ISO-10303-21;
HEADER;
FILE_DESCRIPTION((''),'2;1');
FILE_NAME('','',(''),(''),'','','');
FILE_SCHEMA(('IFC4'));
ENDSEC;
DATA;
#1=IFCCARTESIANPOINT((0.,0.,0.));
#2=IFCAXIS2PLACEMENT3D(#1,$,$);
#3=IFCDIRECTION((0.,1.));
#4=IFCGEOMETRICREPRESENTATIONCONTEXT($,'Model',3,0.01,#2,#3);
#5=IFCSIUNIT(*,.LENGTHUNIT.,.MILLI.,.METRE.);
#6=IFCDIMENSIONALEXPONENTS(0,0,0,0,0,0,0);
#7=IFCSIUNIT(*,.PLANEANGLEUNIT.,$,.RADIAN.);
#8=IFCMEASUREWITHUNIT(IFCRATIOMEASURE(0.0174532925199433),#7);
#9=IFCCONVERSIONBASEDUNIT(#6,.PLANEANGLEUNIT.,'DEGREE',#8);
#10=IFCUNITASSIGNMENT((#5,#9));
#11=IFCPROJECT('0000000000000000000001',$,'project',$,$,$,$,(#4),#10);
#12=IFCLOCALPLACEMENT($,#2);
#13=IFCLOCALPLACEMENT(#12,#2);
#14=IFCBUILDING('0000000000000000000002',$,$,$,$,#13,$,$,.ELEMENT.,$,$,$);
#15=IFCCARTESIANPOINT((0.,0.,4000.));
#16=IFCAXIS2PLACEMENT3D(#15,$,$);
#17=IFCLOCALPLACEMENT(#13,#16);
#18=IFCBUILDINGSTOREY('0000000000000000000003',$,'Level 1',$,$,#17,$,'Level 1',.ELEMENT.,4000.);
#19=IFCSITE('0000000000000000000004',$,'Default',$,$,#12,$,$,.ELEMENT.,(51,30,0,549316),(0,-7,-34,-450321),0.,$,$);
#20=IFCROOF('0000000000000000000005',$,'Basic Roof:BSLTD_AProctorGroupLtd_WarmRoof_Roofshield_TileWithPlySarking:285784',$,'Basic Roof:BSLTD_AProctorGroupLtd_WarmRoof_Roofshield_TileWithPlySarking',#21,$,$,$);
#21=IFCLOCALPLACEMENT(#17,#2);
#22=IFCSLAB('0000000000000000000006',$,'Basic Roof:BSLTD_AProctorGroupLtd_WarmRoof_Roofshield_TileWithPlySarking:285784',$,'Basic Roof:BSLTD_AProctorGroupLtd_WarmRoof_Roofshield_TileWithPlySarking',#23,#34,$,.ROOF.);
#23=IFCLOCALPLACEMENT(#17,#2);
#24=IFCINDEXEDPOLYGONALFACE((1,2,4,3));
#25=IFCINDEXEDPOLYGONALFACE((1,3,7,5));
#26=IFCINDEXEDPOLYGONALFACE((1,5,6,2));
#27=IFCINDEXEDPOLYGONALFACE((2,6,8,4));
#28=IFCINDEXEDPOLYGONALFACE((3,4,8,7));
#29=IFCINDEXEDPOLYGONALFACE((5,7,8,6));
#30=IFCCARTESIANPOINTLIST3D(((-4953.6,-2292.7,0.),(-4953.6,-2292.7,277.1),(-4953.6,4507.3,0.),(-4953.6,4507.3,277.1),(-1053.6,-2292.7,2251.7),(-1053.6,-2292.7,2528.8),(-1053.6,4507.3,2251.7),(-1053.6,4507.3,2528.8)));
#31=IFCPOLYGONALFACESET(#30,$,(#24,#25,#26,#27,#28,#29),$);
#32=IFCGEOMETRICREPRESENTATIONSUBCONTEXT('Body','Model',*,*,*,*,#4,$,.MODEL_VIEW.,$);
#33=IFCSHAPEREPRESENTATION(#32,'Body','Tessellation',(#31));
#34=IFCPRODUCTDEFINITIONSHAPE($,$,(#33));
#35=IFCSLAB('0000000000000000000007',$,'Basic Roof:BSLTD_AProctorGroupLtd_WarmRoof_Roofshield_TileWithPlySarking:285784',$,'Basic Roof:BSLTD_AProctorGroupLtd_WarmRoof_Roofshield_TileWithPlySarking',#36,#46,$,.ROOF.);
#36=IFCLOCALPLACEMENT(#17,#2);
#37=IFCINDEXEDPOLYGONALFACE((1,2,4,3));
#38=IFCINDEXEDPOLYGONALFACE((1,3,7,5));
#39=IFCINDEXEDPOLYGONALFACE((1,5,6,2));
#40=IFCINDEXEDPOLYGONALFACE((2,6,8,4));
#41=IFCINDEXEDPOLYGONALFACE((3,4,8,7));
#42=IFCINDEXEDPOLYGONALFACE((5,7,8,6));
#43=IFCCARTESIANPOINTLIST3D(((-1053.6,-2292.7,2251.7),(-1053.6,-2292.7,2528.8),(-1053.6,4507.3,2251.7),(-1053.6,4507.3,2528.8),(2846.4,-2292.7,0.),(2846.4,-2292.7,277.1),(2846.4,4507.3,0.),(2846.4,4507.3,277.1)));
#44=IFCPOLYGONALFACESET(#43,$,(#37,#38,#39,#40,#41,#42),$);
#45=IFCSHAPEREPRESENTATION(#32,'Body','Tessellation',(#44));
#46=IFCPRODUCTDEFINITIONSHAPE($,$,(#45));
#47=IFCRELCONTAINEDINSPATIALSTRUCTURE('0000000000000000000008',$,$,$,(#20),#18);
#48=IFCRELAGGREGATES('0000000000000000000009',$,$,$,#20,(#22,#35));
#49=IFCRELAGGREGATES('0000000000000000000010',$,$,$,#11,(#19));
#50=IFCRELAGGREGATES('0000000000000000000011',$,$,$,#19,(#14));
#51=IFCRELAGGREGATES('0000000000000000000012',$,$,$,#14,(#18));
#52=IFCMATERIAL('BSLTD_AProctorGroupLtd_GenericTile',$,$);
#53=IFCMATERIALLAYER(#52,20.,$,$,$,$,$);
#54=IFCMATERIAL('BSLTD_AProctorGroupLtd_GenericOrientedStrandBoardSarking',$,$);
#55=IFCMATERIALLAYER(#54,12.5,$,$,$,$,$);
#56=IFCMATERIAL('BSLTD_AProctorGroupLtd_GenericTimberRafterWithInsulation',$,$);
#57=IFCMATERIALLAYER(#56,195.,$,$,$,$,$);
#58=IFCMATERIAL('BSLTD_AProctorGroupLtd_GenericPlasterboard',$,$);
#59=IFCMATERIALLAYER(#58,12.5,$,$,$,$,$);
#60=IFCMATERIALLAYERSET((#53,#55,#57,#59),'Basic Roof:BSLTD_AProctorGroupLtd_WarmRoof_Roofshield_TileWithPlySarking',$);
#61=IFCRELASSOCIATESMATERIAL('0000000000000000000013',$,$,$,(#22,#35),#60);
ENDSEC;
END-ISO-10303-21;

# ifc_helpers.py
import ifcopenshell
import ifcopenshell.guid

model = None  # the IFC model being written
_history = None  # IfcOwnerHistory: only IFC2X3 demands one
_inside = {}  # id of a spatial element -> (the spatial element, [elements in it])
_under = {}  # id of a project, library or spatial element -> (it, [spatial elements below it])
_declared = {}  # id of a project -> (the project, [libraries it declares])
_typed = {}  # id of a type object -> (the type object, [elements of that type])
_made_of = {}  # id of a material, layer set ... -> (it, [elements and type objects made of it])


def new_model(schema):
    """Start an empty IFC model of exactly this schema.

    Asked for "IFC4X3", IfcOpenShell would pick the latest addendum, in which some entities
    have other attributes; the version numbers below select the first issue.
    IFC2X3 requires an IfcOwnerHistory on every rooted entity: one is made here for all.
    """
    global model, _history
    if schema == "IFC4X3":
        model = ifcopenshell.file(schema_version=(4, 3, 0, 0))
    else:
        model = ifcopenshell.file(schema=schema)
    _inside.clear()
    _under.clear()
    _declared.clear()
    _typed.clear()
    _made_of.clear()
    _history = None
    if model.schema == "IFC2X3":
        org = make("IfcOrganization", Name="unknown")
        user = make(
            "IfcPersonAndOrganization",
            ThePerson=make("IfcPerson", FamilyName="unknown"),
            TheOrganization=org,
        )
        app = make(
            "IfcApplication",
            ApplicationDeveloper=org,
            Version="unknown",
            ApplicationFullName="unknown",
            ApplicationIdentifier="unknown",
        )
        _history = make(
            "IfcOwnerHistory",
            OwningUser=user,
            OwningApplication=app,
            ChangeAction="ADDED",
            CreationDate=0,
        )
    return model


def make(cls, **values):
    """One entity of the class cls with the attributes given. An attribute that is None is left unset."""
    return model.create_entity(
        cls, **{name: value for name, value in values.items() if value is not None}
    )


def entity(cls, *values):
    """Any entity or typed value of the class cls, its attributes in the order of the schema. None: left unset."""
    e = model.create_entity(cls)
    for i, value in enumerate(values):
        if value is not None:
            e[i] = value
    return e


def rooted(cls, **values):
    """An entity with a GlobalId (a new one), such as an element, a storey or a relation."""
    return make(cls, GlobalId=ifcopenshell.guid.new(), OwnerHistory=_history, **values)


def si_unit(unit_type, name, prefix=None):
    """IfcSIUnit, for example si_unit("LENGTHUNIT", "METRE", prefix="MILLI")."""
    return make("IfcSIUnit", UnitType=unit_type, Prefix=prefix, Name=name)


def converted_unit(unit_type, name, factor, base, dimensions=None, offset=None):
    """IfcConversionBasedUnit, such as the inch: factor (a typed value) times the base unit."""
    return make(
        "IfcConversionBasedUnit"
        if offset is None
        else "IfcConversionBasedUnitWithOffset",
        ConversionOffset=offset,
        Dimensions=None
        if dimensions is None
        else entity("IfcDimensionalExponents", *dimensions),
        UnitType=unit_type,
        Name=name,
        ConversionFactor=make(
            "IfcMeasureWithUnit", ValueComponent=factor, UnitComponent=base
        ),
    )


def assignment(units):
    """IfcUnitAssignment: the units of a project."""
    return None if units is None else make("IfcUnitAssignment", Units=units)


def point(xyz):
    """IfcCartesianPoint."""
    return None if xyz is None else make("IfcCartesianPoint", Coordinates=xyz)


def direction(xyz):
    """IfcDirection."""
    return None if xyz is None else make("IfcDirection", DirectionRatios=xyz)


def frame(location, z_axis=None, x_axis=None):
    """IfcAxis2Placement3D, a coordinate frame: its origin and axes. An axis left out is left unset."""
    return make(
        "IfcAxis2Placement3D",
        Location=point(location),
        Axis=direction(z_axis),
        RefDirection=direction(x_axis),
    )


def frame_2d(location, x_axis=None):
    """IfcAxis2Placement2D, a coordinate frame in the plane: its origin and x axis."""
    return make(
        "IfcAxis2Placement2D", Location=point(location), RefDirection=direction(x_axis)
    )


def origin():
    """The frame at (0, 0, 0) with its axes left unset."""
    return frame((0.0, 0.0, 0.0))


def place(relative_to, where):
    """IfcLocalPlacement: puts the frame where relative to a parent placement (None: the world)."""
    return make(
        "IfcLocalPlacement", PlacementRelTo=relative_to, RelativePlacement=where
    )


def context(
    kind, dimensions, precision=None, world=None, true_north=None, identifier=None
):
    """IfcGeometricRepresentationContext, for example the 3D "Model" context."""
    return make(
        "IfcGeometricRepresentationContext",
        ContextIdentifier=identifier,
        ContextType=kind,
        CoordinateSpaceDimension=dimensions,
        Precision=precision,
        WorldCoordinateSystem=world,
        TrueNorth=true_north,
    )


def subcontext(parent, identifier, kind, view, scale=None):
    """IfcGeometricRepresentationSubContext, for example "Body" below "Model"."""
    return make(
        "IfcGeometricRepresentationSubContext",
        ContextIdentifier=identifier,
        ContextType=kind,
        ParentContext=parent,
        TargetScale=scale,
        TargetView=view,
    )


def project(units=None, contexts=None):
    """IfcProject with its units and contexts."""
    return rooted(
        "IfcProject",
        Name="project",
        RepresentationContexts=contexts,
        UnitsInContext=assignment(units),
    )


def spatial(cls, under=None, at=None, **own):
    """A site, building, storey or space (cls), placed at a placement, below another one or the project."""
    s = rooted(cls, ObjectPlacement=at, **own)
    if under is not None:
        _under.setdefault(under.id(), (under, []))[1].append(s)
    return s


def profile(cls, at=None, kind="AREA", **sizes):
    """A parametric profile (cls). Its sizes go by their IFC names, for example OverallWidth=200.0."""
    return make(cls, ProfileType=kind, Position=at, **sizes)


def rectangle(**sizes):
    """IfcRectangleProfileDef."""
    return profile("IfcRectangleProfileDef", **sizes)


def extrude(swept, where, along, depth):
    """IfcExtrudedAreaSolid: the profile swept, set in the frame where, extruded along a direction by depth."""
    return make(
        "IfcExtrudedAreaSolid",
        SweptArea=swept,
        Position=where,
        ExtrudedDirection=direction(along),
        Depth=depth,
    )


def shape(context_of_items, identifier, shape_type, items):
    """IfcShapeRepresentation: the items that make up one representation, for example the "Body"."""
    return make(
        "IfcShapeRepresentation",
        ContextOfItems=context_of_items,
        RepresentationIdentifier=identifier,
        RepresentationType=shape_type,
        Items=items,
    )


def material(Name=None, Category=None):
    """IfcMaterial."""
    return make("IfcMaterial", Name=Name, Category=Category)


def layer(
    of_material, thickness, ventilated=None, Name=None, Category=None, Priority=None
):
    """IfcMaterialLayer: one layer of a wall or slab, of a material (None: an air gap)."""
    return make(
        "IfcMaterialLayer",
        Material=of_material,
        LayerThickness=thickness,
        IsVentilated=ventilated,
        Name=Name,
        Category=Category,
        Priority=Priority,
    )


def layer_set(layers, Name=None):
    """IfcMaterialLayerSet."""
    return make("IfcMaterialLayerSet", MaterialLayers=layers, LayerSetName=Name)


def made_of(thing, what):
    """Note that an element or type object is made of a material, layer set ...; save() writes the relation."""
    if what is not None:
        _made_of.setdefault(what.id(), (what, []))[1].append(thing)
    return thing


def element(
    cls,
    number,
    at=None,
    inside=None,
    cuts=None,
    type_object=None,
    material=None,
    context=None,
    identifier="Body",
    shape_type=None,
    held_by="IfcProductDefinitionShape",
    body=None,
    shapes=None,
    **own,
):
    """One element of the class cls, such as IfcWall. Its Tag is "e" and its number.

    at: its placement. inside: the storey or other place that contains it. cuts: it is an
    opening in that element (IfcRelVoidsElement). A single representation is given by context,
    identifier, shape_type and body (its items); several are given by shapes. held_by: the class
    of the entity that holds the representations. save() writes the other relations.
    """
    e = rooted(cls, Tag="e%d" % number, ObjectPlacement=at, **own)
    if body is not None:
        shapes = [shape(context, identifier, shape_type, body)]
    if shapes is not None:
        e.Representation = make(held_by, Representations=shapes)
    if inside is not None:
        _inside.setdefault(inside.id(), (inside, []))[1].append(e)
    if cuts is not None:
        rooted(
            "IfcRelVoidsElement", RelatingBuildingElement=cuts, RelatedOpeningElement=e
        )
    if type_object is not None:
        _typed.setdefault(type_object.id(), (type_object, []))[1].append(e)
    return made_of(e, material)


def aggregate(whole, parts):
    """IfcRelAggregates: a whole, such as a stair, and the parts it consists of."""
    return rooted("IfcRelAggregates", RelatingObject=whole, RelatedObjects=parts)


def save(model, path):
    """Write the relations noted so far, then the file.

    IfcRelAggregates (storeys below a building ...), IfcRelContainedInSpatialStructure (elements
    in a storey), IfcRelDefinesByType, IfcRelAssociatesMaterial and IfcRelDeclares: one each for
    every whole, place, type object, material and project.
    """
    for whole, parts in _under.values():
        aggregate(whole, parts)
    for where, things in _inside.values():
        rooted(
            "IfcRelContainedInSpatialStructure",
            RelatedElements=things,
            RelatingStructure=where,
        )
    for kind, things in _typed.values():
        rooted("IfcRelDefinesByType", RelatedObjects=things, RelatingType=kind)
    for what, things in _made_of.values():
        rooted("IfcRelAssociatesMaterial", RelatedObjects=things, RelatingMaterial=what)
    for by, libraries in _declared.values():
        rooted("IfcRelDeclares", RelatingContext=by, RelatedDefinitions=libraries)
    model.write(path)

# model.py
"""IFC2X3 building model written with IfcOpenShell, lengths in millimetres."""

from ifc_helpers import new_model, entity, si_unit, converted_unit, direction, frame, frame_2d, origin, place, context, subcontext, project, spatial, rectangle, extrude, material, layer, layer_set, element, aggregate, save


model = new_model("IFC2X3")

# Units and contexts
model_context = context("Model", 3, precision=0.01, world=origin(), true_north=direction((0.0, 1.0)))
body_context = subcontext(model_context, "Body", "Model", "MODEL_VIEW")
ifc_project = project(units=[si_unit("LENGTHUNIT", "METRE", prefix="MILLI"), converted_unit("PLANEANGLEUNIT", "DEGREE", entity("IfcRatioMeasure", 0.0174532925199433), si_unit("PLANEANGLEUNIT", "RADIAN"), dimensions=[0, 0, 0, 0, 0, 0, 0])], contexts=[model_context])

# Site, building, storey
site_placement = place(None, origin())
site = spatial("IfcSite", under=ifc_project, at=site_placement, Name="Default", CompositionType="ELEMENT", RefLatitude=(51, 30, 0, 549316), RefLongitude=(0, -7, -34, -450321), RefElevation=0.0)
building_placement = place(site_placement, origin())
building = spatial("IfcBuilding", under=site, at=building_placement, CompositionType="ELEMENT")
storey_placement = place(building_placement, frame((0.0, 0.0, 4000.0)))
storey = spatial("IfcBuildingStorey", under=building, at=storey_placement, Name="Level 1", LongName="Level 1", CompositionType="ELEMENT", Elevation=4000.0)

# Roof, slabs
roof_placement = place(storey_placement, frame((-4953.6, -2292.7, 0.0)))
roof = element("IfcRoof", 1, at=roof_placement, inside=storey, Name="Basic Roof:BSLTD_AProctorGroupLtd_WarmRoof_Roofshield_TileWithPlySarking:285784", ObjectType="Basic Roof:BSLTD_AProctorGroupLtd_WarmRoof_Roofshield_TileWithPlySarking")
ifc_material_1 = material(Name="BSLTD_AProctorGroupLtd_GenericTile")
ifc_layer_1 = layer(ifc_material_1, 20.0)
ifc_material_2 = material(Name="BSLTD_AProctorGroupLtd_GenericOrientedStrandBoardSarking")
ifc_layer_2 = layer(ifc_material_2, 12.5)
ifc_material_3 = material(Name="BSLTD_AProctorGroupLtd_GenericTimberRafterWithInsulation")
ifc_layer_3 = layer(ifc_material_3, 195.0)
ifc_material_4 = material(Name="BSLTD_AProctorGroupLtd_GenericPlasterboard")
ifc_layer_4 = layer(ifc_material_4, 12.5)
ifc_layer_set = layer_set([ifc_layer_1, ifc_layer_2, ifc_layer_3, ifc_layer_4], Name="Basic Roof:BSLTD_AProctorGroupLtd_WarmRoof_Roofshield_TileWithPlySarking")
slab_1_placement = place(roof_placement, origin())
slab_1 = element("IfcSlab", 2, at=slab_1_placement, material=ifc_layer_set, Name="Basic Roof:BSLTD_AProctorGroupLtd_WarmRoof_Roofshield_TileWithPlySarking:285784", ObjectType="Basic Roof:BSLTD_AProctorGroupLtd_WarmRoof_Roofshield_TileWithPlySarking", PredefinedType="ROOF", context=body_context, shape_type="SweptSolid", body=[
    extrude(rectangle(XDim=4503.3, YDim=6800.0, at=frame_2d((0.0, 0.0), x_axis=(-1.0, 0.0))), frame((1950.0, 3400.0, 1125.8), z_axis=(-0.5, 0.0, 0.866025), x_axis=(0.866025, 0.0, 0.5)), (0.5, 0.0, 0.866025), 277.1),
])
slab_2_placement = place(roof_placement, origin())
slab_2 = element("IfcSlab", 3, at=slab_2_placement, material=ifc_layer_set, Name="Basic Roof:BSLTD_AProctorGroupLtd_WarmRoof_Roofshield_TileWithPlySarking:285784", ObjectType="Basic Roof:BSLTD_AProctorGroupLtd_WarmRoof_Roofshield_TileWithPlySarking", PredefinedType="ROOF", context=body_context, shape_type="SweptSolid", body=[
    extrude(rectangle(XDim=6800.0, YDim=4503.3, at=frame_2d((0.0, 0.0), x_axis=(0.0, -1.0))), frame((5850.0, 3400.0, 1125.8), z_axis=(0.5, 0.0, 0.866025), x_axis=(0.866025, 0.0, -0.5)), (-0.5, 0.0, 0.866025), 277.1),
])
aggregate(roof, [slab_1, slab_2])

save(model, "model.ifc")
